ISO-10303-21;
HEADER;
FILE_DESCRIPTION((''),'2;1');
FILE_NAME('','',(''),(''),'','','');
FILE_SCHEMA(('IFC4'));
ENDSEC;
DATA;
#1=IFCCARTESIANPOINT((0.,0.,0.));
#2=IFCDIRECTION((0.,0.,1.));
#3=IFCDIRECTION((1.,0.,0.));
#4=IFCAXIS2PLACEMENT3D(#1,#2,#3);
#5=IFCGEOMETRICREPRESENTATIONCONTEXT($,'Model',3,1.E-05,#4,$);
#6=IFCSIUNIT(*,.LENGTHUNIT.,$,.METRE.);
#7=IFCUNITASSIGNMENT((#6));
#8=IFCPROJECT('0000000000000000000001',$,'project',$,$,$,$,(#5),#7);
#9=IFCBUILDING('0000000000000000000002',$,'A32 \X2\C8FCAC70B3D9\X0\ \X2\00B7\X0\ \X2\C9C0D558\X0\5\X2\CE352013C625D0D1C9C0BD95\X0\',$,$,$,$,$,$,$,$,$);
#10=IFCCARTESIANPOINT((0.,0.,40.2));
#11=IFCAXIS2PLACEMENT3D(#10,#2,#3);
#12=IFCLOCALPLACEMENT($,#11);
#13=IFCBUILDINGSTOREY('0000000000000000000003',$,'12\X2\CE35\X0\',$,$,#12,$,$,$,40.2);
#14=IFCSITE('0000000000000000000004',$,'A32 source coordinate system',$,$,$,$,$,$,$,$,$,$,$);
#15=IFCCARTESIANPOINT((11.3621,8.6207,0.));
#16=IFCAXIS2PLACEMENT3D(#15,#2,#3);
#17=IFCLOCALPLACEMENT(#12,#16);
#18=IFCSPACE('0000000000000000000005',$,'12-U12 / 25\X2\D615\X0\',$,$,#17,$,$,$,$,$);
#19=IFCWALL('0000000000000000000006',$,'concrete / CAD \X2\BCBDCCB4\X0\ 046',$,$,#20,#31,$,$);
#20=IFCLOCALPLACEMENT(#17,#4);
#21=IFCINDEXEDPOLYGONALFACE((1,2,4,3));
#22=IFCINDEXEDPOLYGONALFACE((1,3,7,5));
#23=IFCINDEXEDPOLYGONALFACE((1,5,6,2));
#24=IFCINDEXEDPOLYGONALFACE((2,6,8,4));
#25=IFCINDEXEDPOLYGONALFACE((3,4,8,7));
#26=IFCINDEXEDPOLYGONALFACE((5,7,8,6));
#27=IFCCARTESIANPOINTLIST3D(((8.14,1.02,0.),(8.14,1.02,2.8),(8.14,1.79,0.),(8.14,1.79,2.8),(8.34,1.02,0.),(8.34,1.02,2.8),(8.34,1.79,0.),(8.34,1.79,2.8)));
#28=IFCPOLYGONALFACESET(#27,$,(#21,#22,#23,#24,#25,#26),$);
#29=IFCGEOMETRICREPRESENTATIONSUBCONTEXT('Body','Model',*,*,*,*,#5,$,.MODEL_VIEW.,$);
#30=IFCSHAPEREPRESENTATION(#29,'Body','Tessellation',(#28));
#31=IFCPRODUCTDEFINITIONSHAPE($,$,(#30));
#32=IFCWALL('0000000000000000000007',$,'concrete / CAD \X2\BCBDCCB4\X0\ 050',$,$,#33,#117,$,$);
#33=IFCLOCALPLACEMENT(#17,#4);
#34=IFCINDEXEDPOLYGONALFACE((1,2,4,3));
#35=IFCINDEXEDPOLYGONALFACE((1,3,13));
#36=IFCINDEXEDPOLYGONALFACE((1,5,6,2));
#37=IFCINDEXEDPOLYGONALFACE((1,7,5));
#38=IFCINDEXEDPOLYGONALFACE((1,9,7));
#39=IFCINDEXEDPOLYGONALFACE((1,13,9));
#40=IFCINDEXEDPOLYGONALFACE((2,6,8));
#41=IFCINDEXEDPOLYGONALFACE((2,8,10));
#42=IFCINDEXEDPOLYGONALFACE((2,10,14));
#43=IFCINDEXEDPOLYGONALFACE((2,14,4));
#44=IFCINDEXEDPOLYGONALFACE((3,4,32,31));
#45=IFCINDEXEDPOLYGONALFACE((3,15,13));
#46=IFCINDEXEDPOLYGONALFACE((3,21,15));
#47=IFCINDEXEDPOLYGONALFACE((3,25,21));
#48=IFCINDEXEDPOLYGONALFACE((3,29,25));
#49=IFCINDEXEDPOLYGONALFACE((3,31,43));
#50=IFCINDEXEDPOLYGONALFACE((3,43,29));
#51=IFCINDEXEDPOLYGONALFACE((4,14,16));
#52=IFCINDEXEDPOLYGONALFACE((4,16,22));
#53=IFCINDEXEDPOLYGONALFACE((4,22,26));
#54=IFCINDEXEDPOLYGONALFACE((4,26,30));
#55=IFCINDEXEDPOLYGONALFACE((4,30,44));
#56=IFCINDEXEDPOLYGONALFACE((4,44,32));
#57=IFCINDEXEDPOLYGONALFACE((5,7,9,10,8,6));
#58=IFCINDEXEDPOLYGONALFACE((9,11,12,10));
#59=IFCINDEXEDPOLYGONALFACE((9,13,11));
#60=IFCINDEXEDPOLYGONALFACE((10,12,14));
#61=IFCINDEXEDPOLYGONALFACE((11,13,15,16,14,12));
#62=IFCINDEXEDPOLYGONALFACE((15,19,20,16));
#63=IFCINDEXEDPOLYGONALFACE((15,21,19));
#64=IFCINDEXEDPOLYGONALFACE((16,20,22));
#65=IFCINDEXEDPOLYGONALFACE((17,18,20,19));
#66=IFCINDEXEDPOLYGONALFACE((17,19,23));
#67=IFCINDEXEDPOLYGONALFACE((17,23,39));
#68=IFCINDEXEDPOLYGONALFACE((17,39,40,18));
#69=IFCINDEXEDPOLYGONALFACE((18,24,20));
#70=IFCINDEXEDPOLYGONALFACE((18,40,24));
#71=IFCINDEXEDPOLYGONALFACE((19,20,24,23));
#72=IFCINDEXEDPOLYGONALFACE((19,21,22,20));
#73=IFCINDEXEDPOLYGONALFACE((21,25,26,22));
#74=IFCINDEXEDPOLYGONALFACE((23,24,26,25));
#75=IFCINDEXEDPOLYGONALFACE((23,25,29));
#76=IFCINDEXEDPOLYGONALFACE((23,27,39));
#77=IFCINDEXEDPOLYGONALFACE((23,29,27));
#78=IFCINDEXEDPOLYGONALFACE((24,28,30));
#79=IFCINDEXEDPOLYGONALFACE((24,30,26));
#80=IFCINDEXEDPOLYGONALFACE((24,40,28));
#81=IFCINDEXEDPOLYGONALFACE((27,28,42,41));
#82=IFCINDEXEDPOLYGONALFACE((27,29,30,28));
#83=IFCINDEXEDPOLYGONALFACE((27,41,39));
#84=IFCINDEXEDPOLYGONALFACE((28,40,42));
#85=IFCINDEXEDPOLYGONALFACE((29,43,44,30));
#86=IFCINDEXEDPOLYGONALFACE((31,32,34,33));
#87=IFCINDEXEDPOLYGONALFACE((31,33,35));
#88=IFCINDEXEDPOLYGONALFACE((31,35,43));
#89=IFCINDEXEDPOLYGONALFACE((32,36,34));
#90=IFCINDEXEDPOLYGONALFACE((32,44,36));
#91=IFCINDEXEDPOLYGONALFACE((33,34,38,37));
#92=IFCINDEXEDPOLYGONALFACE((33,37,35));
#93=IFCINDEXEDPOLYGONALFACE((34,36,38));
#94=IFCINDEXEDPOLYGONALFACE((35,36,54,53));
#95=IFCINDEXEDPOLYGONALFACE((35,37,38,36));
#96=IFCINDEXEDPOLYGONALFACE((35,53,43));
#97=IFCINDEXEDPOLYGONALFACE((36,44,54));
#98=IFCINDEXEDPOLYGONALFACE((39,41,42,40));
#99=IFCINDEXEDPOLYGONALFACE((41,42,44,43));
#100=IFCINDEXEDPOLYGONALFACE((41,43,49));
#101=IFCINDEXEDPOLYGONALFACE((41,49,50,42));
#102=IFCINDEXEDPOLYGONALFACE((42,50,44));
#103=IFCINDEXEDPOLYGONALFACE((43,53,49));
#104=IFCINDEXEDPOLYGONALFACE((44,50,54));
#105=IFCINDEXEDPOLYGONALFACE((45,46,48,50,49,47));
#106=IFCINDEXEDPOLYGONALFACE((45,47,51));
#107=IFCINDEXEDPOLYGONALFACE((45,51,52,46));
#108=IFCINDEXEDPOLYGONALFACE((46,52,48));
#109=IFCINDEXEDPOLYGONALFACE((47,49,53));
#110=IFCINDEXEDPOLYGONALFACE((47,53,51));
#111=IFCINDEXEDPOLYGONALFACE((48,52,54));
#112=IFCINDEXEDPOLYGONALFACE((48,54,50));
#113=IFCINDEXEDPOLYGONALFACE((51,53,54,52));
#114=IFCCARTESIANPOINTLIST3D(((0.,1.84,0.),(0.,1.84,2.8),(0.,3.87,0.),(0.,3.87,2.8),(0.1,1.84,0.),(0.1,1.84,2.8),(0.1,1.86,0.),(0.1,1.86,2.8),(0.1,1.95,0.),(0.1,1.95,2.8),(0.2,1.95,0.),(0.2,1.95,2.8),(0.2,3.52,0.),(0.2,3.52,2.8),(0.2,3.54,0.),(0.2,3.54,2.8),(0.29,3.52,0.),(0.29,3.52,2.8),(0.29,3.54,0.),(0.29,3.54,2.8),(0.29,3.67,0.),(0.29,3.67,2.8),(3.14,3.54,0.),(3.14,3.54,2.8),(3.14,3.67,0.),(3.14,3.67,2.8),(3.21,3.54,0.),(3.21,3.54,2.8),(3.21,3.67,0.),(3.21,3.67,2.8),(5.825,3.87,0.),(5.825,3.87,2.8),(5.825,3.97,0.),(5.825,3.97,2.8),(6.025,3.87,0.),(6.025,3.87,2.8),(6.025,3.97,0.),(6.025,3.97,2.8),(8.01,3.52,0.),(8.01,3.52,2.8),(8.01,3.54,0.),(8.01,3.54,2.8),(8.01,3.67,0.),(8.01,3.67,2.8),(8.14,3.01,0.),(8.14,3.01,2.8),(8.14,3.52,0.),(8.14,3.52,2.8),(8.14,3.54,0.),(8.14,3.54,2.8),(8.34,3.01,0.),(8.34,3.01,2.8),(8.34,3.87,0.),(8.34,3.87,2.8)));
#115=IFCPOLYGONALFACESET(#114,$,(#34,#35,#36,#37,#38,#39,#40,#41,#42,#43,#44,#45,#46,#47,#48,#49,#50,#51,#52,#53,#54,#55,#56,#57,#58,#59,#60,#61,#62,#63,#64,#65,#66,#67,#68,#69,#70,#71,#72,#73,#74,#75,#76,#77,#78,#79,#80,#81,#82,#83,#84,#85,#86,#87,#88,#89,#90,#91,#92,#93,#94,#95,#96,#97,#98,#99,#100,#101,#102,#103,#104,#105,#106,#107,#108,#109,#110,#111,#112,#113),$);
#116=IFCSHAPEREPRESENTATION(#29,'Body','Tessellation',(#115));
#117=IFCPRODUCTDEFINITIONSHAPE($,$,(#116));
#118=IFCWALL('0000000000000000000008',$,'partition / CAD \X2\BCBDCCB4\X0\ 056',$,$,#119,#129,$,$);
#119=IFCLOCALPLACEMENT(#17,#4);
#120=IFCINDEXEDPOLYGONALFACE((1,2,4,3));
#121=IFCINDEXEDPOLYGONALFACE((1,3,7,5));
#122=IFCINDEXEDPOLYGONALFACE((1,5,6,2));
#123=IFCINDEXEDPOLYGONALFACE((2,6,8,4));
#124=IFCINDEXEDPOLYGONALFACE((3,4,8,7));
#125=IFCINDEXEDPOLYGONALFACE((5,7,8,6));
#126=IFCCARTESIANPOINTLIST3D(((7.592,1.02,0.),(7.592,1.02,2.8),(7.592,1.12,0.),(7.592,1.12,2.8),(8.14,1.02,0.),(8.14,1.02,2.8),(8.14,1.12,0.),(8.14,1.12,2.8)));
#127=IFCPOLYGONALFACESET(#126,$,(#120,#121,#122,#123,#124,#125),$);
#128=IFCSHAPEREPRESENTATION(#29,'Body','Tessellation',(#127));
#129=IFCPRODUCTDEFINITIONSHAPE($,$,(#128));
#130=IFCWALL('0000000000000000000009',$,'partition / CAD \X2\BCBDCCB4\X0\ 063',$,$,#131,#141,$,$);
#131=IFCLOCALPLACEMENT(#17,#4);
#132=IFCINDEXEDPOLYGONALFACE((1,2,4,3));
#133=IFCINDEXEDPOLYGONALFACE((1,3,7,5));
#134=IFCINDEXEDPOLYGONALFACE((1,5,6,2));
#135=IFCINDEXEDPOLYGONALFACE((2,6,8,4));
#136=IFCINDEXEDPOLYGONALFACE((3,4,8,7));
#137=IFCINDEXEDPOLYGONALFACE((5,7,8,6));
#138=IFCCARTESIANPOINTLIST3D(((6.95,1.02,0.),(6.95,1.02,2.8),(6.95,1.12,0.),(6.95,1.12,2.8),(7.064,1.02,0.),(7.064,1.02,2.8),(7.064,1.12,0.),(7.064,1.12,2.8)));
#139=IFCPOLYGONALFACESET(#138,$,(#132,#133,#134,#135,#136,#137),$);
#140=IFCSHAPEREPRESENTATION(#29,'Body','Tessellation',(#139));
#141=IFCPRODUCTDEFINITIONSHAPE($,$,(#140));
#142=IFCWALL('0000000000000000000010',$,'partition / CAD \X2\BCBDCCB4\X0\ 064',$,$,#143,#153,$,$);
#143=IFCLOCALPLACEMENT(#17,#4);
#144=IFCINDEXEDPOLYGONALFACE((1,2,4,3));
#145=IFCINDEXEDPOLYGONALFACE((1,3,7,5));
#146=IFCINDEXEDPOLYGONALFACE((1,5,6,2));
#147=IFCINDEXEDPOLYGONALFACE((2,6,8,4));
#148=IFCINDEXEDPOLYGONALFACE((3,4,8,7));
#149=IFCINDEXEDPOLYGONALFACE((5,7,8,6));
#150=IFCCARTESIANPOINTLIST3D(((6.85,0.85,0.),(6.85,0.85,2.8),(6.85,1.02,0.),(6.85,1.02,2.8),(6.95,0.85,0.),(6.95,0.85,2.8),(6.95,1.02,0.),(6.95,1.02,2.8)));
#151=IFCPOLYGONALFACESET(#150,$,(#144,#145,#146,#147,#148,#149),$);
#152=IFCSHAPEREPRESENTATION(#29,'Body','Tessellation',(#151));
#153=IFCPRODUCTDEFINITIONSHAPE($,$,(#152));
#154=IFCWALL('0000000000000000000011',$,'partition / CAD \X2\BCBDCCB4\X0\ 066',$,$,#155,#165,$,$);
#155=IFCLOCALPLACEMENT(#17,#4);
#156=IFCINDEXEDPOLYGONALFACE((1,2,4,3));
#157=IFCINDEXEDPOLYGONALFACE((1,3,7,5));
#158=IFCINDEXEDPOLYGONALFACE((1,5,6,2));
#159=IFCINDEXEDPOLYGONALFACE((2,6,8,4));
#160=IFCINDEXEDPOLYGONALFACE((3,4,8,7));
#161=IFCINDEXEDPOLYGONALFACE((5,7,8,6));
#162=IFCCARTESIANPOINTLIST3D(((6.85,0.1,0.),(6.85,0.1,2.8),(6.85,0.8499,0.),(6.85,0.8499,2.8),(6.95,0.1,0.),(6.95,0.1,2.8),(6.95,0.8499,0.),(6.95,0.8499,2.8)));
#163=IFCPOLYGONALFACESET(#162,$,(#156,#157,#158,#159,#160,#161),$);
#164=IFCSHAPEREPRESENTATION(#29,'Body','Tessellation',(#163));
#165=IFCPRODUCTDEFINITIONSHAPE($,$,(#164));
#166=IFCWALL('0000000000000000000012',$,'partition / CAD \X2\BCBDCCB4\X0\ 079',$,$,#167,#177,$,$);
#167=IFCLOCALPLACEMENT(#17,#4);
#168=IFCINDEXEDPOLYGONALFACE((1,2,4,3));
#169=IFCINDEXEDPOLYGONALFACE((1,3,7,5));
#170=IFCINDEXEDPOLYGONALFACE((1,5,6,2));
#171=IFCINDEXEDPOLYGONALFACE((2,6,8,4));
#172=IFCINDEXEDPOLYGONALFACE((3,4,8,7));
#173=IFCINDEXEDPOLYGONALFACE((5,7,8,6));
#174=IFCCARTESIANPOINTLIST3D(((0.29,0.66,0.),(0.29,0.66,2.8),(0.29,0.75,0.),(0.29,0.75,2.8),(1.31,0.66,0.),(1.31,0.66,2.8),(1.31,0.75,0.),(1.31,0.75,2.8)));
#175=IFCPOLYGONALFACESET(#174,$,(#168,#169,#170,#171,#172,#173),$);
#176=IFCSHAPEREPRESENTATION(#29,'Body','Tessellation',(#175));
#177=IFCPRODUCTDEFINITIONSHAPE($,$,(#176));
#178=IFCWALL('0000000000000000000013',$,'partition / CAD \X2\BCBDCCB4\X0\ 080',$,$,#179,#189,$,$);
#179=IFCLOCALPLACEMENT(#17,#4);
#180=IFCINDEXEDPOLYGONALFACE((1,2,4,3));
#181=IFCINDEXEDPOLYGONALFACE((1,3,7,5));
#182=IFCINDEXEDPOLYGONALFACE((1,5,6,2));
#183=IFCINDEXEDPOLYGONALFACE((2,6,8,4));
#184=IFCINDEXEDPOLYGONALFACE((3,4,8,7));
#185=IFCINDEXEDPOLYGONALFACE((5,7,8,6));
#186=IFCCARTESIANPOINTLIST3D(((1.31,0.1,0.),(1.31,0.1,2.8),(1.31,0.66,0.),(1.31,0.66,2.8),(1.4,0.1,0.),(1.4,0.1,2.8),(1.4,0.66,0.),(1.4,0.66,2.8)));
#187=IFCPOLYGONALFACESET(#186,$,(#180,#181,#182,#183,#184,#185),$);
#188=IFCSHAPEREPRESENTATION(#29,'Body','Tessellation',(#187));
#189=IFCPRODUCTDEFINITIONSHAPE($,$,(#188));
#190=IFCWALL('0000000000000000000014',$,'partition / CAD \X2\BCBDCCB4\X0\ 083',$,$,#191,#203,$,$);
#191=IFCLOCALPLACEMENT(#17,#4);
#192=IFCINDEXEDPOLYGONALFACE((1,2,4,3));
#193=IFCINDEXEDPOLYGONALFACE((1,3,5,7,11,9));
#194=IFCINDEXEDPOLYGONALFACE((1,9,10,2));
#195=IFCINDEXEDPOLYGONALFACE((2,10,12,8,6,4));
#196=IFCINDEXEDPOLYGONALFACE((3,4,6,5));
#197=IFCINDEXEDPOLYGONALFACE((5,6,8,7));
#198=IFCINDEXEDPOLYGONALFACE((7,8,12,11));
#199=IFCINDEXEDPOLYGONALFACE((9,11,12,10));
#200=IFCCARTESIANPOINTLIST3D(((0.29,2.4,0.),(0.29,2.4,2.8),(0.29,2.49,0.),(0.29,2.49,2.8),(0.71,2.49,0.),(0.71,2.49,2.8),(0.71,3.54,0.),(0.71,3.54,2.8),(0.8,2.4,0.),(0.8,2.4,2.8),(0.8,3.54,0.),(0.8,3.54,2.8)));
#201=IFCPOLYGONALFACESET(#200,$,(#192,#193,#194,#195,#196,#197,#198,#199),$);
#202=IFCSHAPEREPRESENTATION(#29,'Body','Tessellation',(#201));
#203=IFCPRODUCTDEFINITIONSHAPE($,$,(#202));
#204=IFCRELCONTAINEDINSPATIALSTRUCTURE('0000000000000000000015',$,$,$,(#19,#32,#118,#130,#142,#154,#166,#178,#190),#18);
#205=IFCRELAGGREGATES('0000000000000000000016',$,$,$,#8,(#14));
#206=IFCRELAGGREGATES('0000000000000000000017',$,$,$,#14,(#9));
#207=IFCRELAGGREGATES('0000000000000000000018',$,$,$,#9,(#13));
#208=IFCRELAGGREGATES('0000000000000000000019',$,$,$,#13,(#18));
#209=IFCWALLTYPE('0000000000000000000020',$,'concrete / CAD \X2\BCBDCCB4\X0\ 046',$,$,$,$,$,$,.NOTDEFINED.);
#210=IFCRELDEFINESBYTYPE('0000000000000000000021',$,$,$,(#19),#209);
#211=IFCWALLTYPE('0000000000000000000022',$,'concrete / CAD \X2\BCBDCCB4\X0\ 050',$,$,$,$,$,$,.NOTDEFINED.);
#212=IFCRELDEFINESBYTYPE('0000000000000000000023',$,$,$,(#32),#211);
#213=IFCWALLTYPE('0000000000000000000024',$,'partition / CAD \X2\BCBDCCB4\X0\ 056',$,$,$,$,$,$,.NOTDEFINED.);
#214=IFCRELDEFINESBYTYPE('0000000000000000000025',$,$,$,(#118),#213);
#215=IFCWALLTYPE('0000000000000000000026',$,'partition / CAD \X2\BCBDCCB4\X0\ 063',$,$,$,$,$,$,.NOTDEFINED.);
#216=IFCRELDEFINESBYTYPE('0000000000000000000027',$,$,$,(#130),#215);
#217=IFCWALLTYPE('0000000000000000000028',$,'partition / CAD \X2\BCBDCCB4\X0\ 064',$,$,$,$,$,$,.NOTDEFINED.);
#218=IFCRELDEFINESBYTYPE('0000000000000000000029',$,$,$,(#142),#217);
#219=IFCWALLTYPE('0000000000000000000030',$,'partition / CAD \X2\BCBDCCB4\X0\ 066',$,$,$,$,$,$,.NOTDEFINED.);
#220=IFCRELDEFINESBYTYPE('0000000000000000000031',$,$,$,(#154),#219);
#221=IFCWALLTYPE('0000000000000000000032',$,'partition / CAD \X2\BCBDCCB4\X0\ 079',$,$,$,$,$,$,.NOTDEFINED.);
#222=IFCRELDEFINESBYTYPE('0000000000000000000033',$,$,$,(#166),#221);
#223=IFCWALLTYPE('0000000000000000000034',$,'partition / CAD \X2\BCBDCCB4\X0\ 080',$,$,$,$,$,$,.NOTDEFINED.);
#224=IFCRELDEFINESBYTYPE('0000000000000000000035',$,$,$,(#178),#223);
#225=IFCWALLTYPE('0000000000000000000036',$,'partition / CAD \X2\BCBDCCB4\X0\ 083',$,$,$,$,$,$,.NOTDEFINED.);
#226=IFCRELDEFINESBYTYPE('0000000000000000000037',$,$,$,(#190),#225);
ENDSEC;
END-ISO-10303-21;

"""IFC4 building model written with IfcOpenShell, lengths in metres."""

from ifc_helpers import new_model, si_unit, frame, origin, origin_with_axes, place, context, subcontext, project, spatial, polyline, outline, extrude, source, transform, mapped, type_object, type_shapes, element, save


model = new_model("IFC4")

# Units and contexts
model_context = context("Model", 3, precision=1e-05, world=origin_with_axes())
body_context = subcontext(model_context, "Body", "Model", "MODEL_VIEW")
ifc_project = project(units=[si_unit("LENGTHUNIT", "METRE")], contexts=[model_context])

# Site, building, storey, space
site = spatial("IfcSite", under=ifc_project, Name="A32 source coordinate system")
building = spatial("IfcBuilding", under=site, Name="A32 주거동 · 지하5층–옥탑지붕")
storey_placement = place(None, frame((0.0, 0.0, 40.2), z_axis=(0.0, 0.0, 1.0), x_axis=(1.0, 0.0, 0.0)))
storey = spatial("IfcBuildingStorey", under=building, at=storey_placement, Name="12층", Elevation=40.2)
space_1_placement = place(storey_placement, frame((11.3621, 8.6207, 0.0), z_axis=(0.0, 0.0, 1.0), x_axis=(1.0, 0.0, 0.0)))
space_1 = spatial("IfcSpace", under=storey, at=space_1_placement, Name="12-U12 / 25형")

# Walls
wall_type_1 = type_object("IfcWallType", Name="concrete / CAD 벽체 046", PredefinedType="NOTDEFINED")
shared_shape_1 = source(origin(), body_context, "Body", "SweptSolid", [
    extrude(outline(polyline([(8.14, 1.02), (8.14, 1.79), (8.34, 1.79), (8.34, 1.02), (8.14, 1.02)])), origin(), (0.0, 0.0, 1.0), 2.8),
])
type_shapes(wall_type_1, [shared_shape_1])
wall_1_placement = place(space_1_placement, origin_with_axes())
element("IfcWall", 1, at=wall_1_placement, inside=space_1, type_object=wall_type_1, Name="concrete / CAD 벽체 046", context=body_context, shape_type="MappedRepresentation", body=[
    mapped(shared_shape_1, transform((0.0, 0.0, 0.0), scale=1.0)),
])
wall_type_2 = type_object("IfcWallType", Name="concrete / CAD 벽체 050", PredefinedType="NOTDEFINED")
shared_shape_2 = source(origin(), body_context, "Body", "SweptSolid", [
    extrude(outline(polyline([(8.01, 3.52), (0.29, 3.52), (0.29, 3.54), (0.2, 3.54), (0.2, 3.52), (0.2, 1.95), (0.1, 1.95), (0.1, 1.86), (0.1, 1.84), (0.0, 1.84), (0.0, 3.87), (5.825, 3.87), (5.825, 3.97), (6.025, 3.97), (6.025, 3.87), (8.34, 3.87), (8.34, 3.01), (8.14, 3.01), (8.14, 3.52), (8.14, 3.54), (8.01, 3.54), (8.01, 3.52)]), holes=[polyline([(3.14, 3.54), (3.14, 3.67), (0.29, 3.67), (0.29, 3.54), (3.14, 3.54)]), polyline([(8.01, 3.67), (3.21, 3.67), (3.21, 3.54), (8.01, 3.54), (8.01, 3.67)])]), origin(), (0.0, 0.0, 1.0), 2.8),
])
type_shapes(wall_type_2, [shared_shape_2])
wall_2_placement = place(space_1_placement, origin_with_axes())
element("IfcWall", 2, at=wall_2_placement, inside=space_1, type_object=wall_type_2, Name="concrete / CAD 벽체 050", context=body_context, shape_type="MappedRepresentation", body=[
    mapped(shared_shape_2, transform((0.0, 0.0, 0.0), scale=1.0)),
])
wall_type_3 = type_object("IfcWallType", Name="partition / CAD 벽체 056", PredefinedType="NOTDEFINED")
shared_shape_3 = source(origin(), body_context, "Body", "SweptSolid", [
    extrude(outline(polyline([(7.592, 1.12), (8.14, 1.12), (8.14, 1.02), (7.592, 1.02), (7.592, 1.12)])), origin(), (0.0, 0.0, 1.0), 2.8),
])
type_shapes(wall_type_3, [shared_shape_3])
wall_3_placement = place(space_1_placement, origin_with_axes())
element("IfcWall", 3, at=wall_3_placement, inside=space_1, type_object=wall_type_3, Name="partition / CAD 벽체 056", context=body_context, shape_type="MappedRepresentation", body=[
    mapped(shared_shape_3, transform((0.0, 0.0, 0.0), scale=1.0)),
])
wall_type_4 = type_object("IfcWallType", Name="partition / CAD 벽체 063", PredefinedType="NOTDEFINED")
shared_shape_4 = source(origin(), body_context, "Body", "SweptSolid", [
    extrude(outline(polyline([(6.95, 1.12), (7.064, 1.12), (7.064, 1.02), (6.95, 1.02), (6.95, 1.12)])), origin(), (0.0, 0.0, 1.0), 2.8),
])
type_shapes(wall_type_4, [shared_shape_4])
wall_4_placement = place(space_1_placement, origin_with_axes())
element("IfcWall", 4, at=wall_4_placement, inside=space_1, type_object=wall_type_4, Name="partition / CAD 벽체 063", context=body_context, shape_type="MappedRepresentation", body=[
    mapped(shared_shape_4, transform((0.0, 0.0, 0.0), scale=1.0)),
])
wall_type_5 = type_object("IfcWallType", Name="partition / CAD 벽체 064", PredefinedType="NOTDEFINED")
shared_shape_5 = source(origin(), body_context, "Body", "SweptSolid", [
    extrude(outline(polyline([(6.95, 0.85), (6.85, 0.85), (6.85, 1.02), (6.95, 1.02), (6.95, 0.85)])), origin(), (0.0, 0.0, 1.0), 2.8),
])
type_shapes(wall_type_5, [shared_shape_5])
wall_5_placement = place(space_1_placement, origin_with_axes())
element("IfcWall", 5, at=wall_5_placement, inside=space_1, type_object=wall_type_5, Name="partition / CAD 벽체 064", context=body_context, shape_type="MappedRepresentation", body=[
    mapped(shared_shape_5, transform((0.0, 0.0, 0.0), scale=1.0)),
])
wall_type_6 = type_object("IfcWallType", Name="partition / CAD 벽체 066", PredefinedType="NOTDEFINED")
shared_shape_6 = source(origin(), body_context, "Body", "SweptSolid", [
    extrude(outline(polyline([(6.85, 0.8499), (6.95, 0.8499), (6.95, 0.1), (6.85, 0.1), (6.85, 0.8499)])), origin(), (0.0, 0.0, 1.0), 2.8),
])
type_shapes(wall_type_6, [shared_shape_6])
wall_6_placement = place(space_1_placement, origin_with_axes())
element("IfcWall", 6, at=wall_6_placement, inside=space_1, type_object=wall_type_6, Name="partition / CAD 벽체 066", context=body_context, shape_type="MappedRepresentation", body=[
    mapped(shared_shape_6, transform((0.0, 0.0, 0.0), scale=1.0)),
])
wall_type_7 = type_object("IfcWallType", Name="partition / CAD 벽체 079", PredefinedType="NOTDEFINED")
shared_shape_7 = source(origin(), body_context, "Body", "SweptSolid", [
    extrude(outline(polyline([(0.29, 0.75), (1.31, 0.75), (1.31, 0.66), (0.29, 0.66), (0.29, 0.75)])), origin(), (0.0, 0.0, 1.0), 2.8),
])
type_shapes(wall_type_7, [shared_shape_7])
wall_7_placement = place(space_1_placement, origin_with_axes())
element("IfcWall", 7, at=wall_7_placement, inside=space_1, type_object=wall_type_7, Name="partition / CAD 벽체 079", context=body_context, shape_type="MappedRepresentation", body=[
    mapped(shared_shape_7, transform((0.0, 0.0, 0.0), scale=1.0)),
])
wall_type_8 = type_object("IfcWallType", Name="partition / CAD 벽체 080", PredefinedType="NOTDEFINED")
shared_shape_8 = source(origin(), body_context, "Body", "SweptSolid", [
    extrude(outline(polyline([(1.4, 0.66), (1.4, 0.1), (1.31, 0.1), (1.31, 0.66), (1.4, 0.66)])), origin(), (0.0, 0.0, 1.0), 2.8),
])
type_shapes(wall_type_8, [shared_shape_8])
wall_8_placement = place(space_1_placement, origin_with_axes())
element("IfcWall", 8, at=wall_8_placement, inside=space_1, type_object=wall_type_8, Name="partition / CAD 벽체 080", context=body_context, shape_type="MappedRepresentation", body=[
    mapped(shared_shape_8, transform((0.0, 0.0, 0.0), scale=1.0)),
])
wall_type_9 = type_object("IfcWallType", Name="partition / CAD 벽체 083", PredefinedType="NOTDEFINED")
shared_shape_9 = source(origin(), body_context, "Body", "SweptSolid", [
    extrude(outline(polyline([(0.71, 2.49), (0.71, 3.54), (0.8, 3.54), (0.8, 2.4), (0.29, 2.4), (0.29, 2.49), (0.71, 2.49)])), origin(), (0.0, 0.0, 1.0), 2.8),
])
type_shapes(wall_type_9, [shared_shape_9])
wall_9_placement = place(space_1_placement, origin_with_axes())
element("IfcWall", 9, at=wall_9_placement, inside=space_1, type_object=wall_type_9, Name="partition / CAD 벽체 083", context=body_context, shape_type="MappedRepresentation", body=[
    mapped(shared_shape_9, transform((0.0, 0.0, 0.0), scale=1.0)),
])

save(model, "model.ifc")
